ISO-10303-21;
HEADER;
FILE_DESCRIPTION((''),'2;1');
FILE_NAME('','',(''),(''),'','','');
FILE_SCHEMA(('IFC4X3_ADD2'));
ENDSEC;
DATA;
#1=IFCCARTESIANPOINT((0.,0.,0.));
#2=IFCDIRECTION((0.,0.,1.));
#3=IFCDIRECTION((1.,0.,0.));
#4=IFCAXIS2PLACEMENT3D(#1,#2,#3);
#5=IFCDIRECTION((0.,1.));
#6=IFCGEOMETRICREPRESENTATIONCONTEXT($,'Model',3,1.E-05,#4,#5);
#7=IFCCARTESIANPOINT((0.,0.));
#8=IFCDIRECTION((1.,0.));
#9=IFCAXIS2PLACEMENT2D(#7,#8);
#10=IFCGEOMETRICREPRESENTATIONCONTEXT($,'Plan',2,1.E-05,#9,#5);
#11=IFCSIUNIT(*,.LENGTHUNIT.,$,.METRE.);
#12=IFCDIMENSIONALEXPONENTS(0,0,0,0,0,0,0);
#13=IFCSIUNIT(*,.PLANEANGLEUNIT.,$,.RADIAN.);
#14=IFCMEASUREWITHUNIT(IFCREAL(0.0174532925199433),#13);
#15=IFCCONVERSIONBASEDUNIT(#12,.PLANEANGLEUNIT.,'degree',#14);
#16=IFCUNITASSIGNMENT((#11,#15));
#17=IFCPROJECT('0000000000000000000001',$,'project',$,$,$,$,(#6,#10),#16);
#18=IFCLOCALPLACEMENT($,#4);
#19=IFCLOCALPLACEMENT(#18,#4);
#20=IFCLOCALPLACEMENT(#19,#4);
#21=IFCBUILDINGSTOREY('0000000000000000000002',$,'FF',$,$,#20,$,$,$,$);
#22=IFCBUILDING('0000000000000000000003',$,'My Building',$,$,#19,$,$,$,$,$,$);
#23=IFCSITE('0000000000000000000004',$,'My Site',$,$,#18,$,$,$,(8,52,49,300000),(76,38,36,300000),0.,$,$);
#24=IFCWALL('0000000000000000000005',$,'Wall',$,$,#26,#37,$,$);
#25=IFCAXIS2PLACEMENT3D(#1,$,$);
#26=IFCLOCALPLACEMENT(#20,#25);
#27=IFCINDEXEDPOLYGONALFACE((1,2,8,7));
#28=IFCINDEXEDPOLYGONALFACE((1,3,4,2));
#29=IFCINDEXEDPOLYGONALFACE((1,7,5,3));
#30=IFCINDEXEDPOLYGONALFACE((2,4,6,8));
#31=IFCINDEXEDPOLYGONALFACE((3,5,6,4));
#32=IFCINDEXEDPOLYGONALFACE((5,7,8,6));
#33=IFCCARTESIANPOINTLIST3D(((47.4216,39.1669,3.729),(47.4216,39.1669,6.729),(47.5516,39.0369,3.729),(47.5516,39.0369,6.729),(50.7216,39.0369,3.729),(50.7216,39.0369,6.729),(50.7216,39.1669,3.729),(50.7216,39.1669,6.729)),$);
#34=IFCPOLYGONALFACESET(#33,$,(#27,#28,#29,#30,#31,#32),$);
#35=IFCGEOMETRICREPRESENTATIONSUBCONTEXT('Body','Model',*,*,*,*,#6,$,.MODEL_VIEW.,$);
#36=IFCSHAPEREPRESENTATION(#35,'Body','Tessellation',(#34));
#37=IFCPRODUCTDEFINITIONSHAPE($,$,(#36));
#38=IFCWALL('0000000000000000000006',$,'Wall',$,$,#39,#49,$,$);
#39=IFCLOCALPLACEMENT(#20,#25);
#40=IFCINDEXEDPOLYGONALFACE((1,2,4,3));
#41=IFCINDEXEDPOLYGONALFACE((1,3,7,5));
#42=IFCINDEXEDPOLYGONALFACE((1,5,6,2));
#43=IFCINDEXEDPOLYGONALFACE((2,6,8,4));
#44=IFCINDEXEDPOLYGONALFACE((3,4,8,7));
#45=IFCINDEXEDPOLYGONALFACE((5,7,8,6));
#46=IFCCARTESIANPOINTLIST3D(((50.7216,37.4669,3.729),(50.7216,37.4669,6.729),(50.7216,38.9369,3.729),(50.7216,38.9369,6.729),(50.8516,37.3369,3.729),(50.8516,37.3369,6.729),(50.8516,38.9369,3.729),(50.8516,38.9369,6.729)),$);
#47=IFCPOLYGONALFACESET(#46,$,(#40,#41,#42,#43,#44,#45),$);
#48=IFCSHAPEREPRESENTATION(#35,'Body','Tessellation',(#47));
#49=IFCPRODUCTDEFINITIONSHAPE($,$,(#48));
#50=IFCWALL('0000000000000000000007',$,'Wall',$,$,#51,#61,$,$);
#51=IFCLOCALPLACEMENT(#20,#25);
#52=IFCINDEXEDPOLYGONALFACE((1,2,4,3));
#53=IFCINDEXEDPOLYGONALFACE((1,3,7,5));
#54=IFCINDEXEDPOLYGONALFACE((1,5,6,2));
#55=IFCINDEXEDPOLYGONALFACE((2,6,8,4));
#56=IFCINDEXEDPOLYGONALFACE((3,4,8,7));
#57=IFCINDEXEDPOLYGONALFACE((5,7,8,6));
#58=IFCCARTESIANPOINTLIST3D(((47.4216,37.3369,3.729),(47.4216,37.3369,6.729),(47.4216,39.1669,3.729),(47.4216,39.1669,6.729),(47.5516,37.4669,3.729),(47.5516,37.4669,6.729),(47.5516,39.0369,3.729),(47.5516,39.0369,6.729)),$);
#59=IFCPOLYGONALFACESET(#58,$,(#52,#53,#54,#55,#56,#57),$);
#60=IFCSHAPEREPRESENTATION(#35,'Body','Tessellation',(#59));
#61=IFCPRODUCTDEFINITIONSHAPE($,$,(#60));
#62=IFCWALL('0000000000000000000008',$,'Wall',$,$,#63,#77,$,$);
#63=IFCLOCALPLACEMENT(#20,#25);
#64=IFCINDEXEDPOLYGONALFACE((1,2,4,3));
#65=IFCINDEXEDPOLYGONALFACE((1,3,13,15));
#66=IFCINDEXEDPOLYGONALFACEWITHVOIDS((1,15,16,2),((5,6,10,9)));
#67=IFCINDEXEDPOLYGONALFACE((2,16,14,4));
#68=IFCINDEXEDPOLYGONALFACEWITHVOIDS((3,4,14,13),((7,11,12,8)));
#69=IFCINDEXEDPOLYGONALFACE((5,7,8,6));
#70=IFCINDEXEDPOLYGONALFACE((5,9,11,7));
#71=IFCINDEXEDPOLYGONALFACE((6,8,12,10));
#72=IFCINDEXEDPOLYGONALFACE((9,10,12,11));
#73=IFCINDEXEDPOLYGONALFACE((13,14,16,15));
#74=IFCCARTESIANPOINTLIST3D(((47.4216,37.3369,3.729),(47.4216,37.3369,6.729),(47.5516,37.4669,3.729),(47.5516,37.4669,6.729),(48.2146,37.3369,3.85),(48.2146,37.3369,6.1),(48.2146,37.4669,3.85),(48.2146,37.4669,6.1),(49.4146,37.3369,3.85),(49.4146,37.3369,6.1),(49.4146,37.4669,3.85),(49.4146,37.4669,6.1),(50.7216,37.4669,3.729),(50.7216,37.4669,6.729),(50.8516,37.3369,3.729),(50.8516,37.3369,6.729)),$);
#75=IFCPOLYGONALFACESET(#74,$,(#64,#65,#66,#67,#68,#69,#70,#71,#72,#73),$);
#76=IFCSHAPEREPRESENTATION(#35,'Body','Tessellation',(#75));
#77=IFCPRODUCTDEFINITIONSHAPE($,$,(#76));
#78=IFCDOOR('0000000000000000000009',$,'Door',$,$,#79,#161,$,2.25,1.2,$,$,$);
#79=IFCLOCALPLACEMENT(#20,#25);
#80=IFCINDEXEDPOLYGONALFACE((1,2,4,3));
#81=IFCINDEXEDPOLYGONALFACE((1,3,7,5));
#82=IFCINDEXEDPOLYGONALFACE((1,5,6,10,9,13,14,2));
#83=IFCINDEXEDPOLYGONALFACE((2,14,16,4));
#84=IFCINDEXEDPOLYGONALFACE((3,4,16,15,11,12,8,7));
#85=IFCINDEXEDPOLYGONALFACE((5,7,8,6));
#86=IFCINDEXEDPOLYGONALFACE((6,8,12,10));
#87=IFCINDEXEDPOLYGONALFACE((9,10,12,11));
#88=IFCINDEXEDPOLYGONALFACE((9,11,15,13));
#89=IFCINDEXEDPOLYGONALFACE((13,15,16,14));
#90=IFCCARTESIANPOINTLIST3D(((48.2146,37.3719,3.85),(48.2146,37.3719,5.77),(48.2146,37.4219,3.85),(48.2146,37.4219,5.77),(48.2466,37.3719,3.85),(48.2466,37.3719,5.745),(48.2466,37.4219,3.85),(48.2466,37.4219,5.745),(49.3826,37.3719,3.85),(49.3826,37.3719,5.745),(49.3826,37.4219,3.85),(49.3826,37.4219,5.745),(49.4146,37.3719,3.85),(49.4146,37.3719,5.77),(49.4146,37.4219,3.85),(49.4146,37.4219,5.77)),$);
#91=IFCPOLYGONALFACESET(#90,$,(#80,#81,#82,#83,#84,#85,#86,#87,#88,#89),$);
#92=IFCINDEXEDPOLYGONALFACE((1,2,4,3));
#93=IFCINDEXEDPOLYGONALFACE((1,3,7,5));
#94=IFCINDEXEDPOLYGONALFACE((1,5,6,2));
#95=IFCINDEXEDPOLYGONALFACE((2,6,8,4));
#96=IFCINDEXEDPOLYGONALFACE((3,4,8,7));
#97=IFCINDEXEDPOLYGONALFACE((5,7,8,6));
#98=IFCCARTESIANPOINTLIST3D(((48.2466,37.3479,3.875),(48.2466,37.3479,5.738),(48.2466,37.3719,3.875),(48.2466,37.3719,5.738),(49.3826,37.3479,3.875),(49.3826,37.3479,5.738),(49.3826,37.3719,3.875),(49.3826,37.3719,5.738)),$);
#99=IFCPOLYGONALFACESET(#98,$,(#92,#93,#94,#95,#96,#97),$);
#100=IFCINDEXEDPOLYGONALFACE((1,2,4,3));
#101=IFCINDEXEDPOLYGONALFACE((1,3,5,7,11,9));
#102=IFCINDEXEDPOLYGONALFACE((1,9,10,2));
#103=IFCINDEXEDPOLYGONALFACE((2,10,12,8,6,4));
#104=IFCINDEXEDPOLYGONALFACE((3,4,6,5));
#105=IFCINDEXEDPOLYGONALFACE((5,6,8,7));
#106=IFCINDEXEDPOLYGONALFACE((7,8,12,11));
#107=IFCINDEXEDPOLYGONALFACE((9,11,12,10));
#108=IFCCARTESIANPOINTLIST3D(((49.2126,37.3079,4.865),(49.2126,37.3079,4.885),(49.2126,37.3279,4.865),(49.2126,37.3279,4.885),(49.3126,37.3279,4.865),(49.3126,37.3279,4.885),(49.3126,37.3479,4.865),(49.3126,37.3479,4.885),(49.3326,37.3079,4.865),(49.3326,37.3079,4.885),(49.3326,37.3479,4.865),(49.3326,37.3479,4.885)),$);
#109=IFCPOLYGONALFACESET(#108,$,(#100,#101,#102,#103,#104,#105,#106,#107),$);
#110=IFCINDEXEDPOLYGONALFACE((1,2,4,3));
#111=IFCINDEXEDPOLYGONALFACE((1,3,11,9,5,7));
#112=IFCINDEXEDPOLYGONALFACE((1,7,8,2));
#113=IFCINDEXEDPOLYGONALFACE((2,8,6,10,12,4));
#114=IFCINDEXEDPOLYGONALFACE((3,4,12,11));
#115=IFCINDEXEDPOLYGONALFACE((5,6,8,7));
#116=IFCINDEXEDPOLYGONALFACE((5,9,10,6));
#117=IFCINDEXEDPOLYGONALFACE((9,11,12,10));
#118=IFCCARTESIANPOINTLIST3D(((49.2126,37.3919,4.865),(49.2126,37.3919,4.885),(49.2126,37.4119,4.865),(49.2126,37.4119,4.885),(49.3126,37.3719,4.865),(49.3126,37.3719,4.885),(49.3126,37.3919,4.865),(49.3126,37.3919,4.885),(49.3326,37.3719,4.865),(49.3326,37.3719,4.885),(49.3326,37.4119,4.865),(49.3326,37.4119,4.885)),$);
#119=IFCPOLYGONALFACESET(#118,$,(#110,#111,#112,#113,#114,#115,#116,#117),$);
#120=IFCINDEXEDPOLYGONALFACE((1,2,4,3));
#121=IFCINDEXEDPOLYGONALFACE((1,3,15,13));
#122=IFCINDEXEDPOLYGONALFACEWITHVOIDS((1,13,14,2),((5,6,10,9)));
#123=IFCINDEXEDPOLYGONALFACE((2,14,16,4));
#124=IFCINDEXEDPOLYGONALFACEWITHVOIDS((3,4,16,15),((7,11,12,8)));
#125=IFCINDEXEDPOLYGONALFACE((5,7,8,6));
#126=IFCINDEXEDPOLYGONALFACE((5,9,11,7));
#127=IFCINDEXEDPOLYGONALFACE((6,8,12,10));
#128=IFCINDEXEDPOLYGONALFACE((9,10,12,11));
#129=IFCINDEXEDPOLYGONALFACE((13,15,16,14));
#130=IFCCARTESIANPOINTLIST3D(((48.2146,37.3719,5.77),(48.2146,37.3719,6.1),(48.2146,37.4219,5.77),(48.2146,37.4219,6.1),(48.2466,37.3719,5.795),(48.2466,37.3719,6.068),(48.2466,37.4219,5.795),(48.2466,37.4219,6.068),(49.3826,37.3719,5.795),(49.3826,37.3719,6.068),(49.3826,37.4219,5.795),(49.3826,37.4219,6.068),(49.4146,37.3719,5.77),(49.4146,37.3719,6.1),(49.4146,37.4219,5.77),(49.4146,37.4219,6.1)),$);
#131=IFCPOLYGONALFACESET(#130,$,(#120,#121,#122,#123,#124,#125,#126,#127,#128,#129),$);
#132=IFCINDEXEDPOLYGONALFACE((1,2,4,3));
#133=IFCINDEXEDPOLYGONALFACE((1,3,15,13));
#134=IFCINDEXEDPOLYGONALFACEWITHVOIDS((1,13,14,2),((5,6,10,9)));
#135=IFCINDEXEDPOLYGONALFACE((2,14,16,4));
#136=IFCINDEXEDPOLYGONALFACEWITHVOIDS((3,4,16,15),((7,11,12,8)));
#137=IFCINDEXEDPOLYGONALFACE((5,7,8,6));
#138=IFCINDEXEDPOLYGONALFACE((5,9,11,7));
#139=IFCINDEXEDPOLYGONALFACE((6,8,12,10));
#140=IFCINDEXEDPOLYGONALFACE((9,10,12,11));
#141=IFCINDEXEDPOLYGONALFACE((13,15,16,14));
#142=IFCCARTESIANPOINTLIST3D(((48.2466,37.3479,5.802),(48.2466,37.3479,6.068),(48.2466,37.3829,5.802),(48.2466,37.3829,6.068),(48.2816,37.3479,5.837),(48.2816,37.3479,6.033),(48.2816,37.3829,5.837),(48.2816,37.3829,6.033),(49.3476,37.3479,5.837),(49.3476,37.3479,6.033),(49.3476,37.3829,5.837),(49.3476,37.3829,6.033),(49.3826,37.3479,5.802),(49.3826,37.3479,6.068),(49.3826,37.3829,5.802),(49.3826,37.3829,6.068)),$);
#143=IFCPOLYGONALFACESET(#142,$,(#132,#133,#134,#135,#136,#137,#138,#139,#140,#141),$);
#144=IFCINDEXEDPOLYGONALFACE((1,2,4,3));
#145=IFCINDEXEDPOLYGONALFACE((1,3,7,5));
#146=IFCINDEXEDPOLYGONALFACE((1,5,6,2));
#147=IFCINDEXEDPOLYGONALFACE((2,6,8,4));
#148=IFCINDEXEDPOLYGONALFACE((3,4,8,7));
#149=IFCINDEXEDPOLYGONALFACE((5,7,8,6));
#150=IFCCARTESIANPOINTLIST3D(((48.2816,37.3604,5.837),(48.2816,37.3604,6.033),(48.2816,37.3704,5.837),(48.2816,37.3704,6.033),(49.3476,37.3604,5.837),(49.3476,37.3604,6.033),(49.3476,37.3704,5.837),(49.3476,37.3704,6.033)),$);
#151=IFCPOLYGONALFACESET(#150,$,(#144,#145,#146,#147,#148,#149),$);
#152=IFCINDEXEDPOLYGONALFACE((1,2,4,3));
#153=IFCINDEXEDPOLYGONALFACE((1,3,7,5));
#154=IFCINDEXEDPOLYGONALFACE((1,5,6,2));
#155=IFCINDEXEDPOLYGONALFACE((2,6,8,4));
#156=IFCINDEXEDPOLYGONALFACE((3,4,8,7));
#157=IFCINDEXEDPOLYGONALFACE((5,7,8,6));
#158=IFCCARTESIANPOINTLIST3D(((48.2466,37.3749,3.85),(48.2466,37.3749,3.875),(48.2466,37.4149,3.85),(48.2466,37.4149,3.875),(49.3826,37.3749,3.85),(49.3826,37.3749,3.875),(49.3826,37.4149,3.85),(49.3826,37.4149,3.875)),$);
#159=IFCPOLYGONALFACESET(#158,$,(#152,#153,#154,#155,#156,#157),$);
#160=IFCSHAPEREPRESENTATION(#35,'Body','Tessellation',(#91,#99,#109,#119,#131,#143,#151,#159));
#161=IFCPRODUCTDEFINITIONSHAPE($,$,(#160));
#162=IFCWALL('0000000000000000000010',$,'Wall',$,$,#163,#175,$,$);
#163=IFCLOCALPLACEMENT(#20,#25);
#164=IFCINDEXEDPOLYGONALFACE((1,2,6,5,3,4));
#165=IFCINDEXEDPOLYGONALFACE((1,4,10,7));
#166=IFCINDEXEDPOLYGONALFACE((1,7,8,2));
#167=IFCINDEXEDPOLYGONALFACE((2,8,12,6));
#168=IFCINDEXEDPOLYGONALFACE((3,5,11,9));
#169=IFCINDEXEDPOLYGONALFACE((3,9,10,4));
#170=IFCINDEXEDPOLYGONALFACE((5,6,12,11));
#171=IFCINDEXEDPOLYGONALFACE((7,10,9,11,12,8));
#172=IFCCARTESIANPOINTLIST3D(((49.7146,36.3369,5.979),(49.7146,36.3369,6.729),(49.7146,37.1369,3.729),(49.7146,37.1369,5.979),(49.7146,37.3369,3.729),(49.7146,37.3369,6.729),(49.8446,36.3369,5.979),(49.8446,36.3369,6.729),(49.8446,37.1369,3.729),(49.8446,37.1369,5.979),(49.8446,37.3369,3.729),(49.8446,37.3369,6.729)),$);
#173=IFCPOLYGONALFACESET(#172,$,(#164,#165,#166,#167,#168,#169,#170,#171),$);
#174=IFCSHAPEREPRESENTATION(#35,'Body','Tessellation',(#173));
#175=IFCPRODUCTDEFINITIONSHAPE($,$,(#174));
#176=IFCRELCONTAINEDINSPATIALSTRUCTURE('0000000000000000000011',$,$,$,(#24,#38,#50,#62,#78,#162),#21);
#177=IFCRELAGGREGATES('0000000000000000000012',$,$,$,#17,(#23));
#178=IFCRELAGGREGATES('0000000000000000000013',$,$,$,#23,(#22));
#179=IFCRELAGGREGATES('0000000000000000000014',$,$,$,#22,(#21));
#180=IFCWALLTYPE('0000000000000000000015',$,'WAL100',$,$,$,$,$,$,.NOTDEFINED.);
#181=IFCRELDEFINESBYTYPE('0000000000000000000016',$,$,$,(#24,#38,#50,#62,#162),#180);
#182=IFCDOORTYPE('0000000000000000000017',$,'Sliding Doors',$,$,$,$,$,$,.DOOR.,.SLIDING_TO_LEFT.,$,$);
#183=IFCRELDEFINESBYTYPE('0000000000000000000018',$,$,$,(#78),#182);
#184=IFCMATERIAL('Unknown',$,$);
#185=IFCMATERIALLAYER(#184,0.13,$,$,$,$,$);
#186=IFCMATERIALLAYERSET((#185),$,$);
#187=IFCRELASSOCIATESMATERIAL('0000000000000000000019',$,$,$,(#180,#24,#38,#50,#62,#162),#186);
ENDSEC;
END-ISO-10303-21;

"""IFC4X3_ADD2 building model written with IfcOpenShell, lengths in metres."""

from ifc_helpers import new_model, entity, si_unit, converted_unit, direction, frame, origin_with_axes, origin_2d_with_axis, place, context, subcontext, project, spatial, line, indexed_curve, outline, extrude, shape, source, transform, mapped, material, layer, layer_set, layer_usage, type_object, type_shapes, element, fill, save


model = new_model("IFC4X3_ADD2")

# Units and contexts
model_context = context("Model", 3, precision=1e-05, world=origin_with_axes(), true_north=direction((0.0, 1.0)))
plan_context = context("Plan", 2, precision=1e-05, world=origin_2d_with_axis(), true_north=direction((0.0, 1.0)))
body_context_1 = subcontext(model_context, "Body", "Model", "MODEL_VIEW")
body_context_2 = subcontext(plan_context, "Body", "Plan", "PLAN_VIEW")
ifc_project = project(units=[si_unit("LENGTHUNIT", "METRE"), converted_unit("PLANEANGLEUNIT", "degree", entity("IfcReal", 0.0174532925199433), si_unit("PLANEANGLEUNIT", "RADIAN"), dimensions=[0, 0, 0, 0, 0, 0, 0])], contexts=[model_context, plan_context])

# Site, building, storey
site_placement = place(None, origin_with_axes())
site = spatial("IfcSite", under=ifc_project, at=site_placement, Name="My Site", RefLatitude=(8, 52, 49, 300000), RefLongitude=(76, 38, 36, 300000), RefElevation=0.0)
building_placement = place(site_placement, origin_with_axes())
building = spatial("IfcBuilding", under=site, at=building_placement, Name="My Building")
storey_placement = place(building_placement, origin_with_axes())
storey = spatial("IfcBuildingStorey", under=building, at=storey_placement, Name="FF")

# Walls
ifc_material_1 = material(Name="Unknown")
ifc_layer_1 = layer(ifc_material_1, 0.13)
ifc_layer_set_1 = layer_set([ifc_layer_1])
ifc_layer_usage_1 = layer_usage(ifc_layer_set_1, "AXIS2", "POSITIVE", 0.0)
wall_type_1 = type_object("IfcWallType", Name="WAL100", PredefinedType="NOTDEFINED", material=ifc_layer_set_1)
wall_1_placement = place(storey_placement, frame((50.7216, 39.1669, 3.729), z_axis=(0.0, 0.0, 1.0), x_axis=(-1.0, 0.0, 0.0)))
element("IfcWall", 1, at=wall_1_placement, inside=storey, type_object=wall_type_1, material=ifc_layer_usage_1, Name="Wall", context=body_context_1, shape_type="SweptSolid", body=[
    extrude(outline(indexed_curve([(0.0, 0.0), (0.0, 0.13), (3.17, 0.13), (3.3, 0.0)], segments=[line(1, 2, 3, 4, 1)])), origin_with_axes(), (0.0, 0.0, 1.0), 3.0),
])
ifc_layer_usage_2 = layer_usage(ifc_layer_set_1, "AXIS2", "POSITIVE", 0.0)
wall_2_placement = place(storey_placement, frame((50.7216, 38.9369, 3.729), z_axis=(0.0, 0.0, 1.0), x_axis=(-0.000001, -1.0, 0.0)))
element("IfcWall", 2, at=wall_2_placement, inside=storey, type_object=wall_type_1, material=ifc_layer_usage_2, Name="Wall", context=body_context_1, shape_type="SweptSolid", body=[
    extrude(outline(indexed_curve([(0.0, 0.0), (0.0, 0.13), (1.6, 0.13), (1.47, 0.0)], segments=[line(1, 2, 3, 4, 1)])), origin_with_axes(), (0.0, 0.0, 1.0), 3.0),
])
ifc_layer_usage_3 = layer_usage(ifc_layer_set_1, "AXIS2", "POSITIVE", 0.0)
wall_3_placement = place(storey_placement, frame((47.4216, 39.1669, 3.729), z_axis=(0.0, 0.0, 1.0), x_axis=(-0.000001, -1.0, 0.0)))
element("IfcWall", 3, at=wall_3_placement, inside=storey, type_object=wall_type_1, material=ifc_layer_usage_3, Name="Wall", context=body_context_1, shape_type="SweptSolid", body=[
    extrude(outline(indexed_curve([(0.0, 0.0), (0.13, 0.13), (1.7, 0.13), (1.83, 0.0)], segments=[line(1, 2, 3, 4, 1)])), origin_with_axes(), (0.0, 0.0, 1.0), 3.0),
])

# Wall, opening, door
ifc_layer_usage_4 = layer_usage(ifc_layer_set_1, "AXIS2", "POSITIVE", 0.0)
wall_4_placement = place(storey_placement, frame((47.4216, 37.3369, 3.729), z_axis=(0.0, 0.0, 1.0), x_axis=(1.0, -0.000001, 0.0)))
wall_4 = element("IfcWall", 4, at=wall_4_placement, inside=storey, type_object=wall_type_1, material=ifc_layer_usage_4, Name="Wall", context=body_context_1, shape_type="SweptSolid", body=[
    extrude(outline(indexed_curve([(0.0, 0.0), (0.13, 0.13), (3.3, 0.13), (3.43, 0.0)], segments=[line(1, 2, 3, 4, 1)])), origin_with_axes(), (0.0, 0.0, 1.0), 3.0),
])
shared_shape_1 = source(origin_with_axes(), body_context_1, "Body", "SweptSolid", [
    extrude(outline(indexed_curve([(0.0, 0.0), (1.2, 0.0), (1.2, 2.25), (0.0, 2.25)], segments=[line(1, 2, 3, 4, 1)])), frame((0.0, -0.6, 0.0), z_axis=(0.0, -1.0, 0.0), x_axis=(1.0, 0.0, 0.0)), (0.0, 0.0, -1.0), 1.2),
])
opening_1_placement = place(wall_4_placement, frame((0.7929, 0.0, 0.121), z_axis=(0.0, 0.0, 1.0), x_axis=(1.0, 0.0, 0.0)))
opening_1 = element("IfcOpeningElement", 5, at=opening_1_placement, cuts=wall_4, PredefinedType="OPENING", context=body_context_1, shape_type="MappedRepresentation", body=[
    mapped(shared_shape_1, transform((0.0, 0.0, 0.0), x_axis=(1.0, 0.0, 0.0), y_axis=(0.0, 1.0, 0.0), z_axis=(0.0, 0.0, 1.0), scale=1.0)),
])
door_type = type_object("IfcDoorType", Name="Sliding Doors", OperationType="SLIDING_TO_LEFT", PredefinedType="DOOR")
shared_shape_2 = source(origin_with_axes(), body_context_1, "Body", "SweptSolid", [
    extrude(outline(indexed_curve([(0.0, 0.0), (0.0, 1.92), (1.2, 1.92), (1.2, 0.0), (1.168, 0.0), (1.168, 1.895), (0.032, 1.895), (0.032, 0.0)], segments=[line(1, 2, 3, 4, 5, 6, 7, 8, 1)])), frame((0.0, 0.035, 0.0), z_axis=(0.0, -1.0, 0.0), x_axis=(1.0, 0.0, 0.0)), (0.0, 0.0, -1.0), 0.05),
    extrude(outline(indexed_curve([(0.0, 0.0), (1.136, 0.0), (1.136, 0.024), (0.0, 0.024)], segments=[line(1, 2, 3, 4, 1)])), frame((0.032, 0.011, 0.025), z_axis=(0.0, 0.0, 1.0), x_axis=(1.0, 0.0, 0.0)), (0.0, 0.0, 1.0), 1.863),
    extrude(outline(indexed_curve([(0.0, 0.0), (0.0, -0.04), (-0.12, -0.04), (-0.12, -0.02), (-0.02, -0.02), (-0.02, 0.0)], segments=[line(1, 2, 3, 4, 5, 6, 1)])), frame((1.118, 0.011, 1.015), z_axis=(0.0, 0.0, 1.0), x_axis=(1.0, 0.0, 0.0)), (0.0, 0.0, 1.0), 0.02),
    extrude(outline(indexed_curve([(0.0, 0.0), (0.0, 0.04), (-0.12, 0.04), (-0.12, 0.02), (-0.02, 0.02), (-0.02, 0.0)], segments=[line(1, 2, 3, 4, 5, 6, 1)])), frame((1.118, 0.035, 1.015), z_axis=(0.0, 0.0, 1.0), x_axis=(1.0, 0.0, 0.0)), (0.0, 0.0, 1.0), 0.02),
    extrude(outline(indexed_curve([(0.0, 0.0), (1.2, 0.0), (1.2, 0.33), (0.0, 0.33)], segments=[line(1, 2, 3, 4, 1)]), holes=[indexed_curve([(0.032, 0.025), (1.168, 0.025), (1.168, 0.298), (0.032, 0.298)], segments=[line(1, 2, 3, 4, 1)])]), frame((0.0, 0.035, 1.92), z_axis=(0.0, -1.0, 0.0), x_axis=(1.0, 0.0, 0.0)), (0.0, 0.0, -1.0), 0.05),
    extrude(outline(indexed_curve([(0.0, 0.0), (1.136, 0.0), (1.136, 0.266), (0.0, 0.266)], segments=[line(1, 2, 3, 4, 1)]), holes=[indexed_curve([(0.035, 0.035), (1.101, 0.035), (1.101, 0.231), (0.035, 0.231)], segments=[line(1, 2, 3, 4, 1)])]), frame((0.032, 0.011, 1.952), z_axis=(0.0, -1.0, 0.0), x_axis=(1.0, 0.0, 0.0)), (0.0, 0.0, -1.0), 0.035),
    extrude(outline(indexed_curve([(0.035, 0.035), (1.101, 0.035), (1.101, 0.231), (0.035, 0.231)], segments=[line(1, 2, 3, 4, 1)])), frame((0.032, 0.0235, 1.952), z_axis=(0.0, -1.0, 0.0), x_axis=(1.0, 0.0, 0.0)), (0.0, 0.0, -1.0), 0.01),
    extrude(outline(indexed_curve([(0.0, 0.0), (1.136, 0.0), (1.136, 0.04), (0.0, 0.04)], segments=[line(1, 2, 3, 4, 1)])), frame((0.032, 0.038, 0.0), z_axis=(0.0, 0.0, 1.0), x_axis=(1.0, 0.0, 0.0)), (0.0, 0.0, 1.0), 0.025),
])
shared_shape_3 = source(origin_with_axes(), body_context_2, "Body", "Curve2D", [
    entity("IfcIndexedPolyCurve", entity("IfcCartesianPointList2D", [[0.0, 0.035], [0.032, 0.035], [0.032, 0.085], [0.0, 0.085]]), [entity("IfcLineIndex", [1, 2, 3, 4, 1])]),
    entity("IfcIndexedPolyCurve", entity("IfcCartesianPointList2D", [[1.2, 0.035], [1.168, 0.035], [1.168, 0.085], [1.2, 0.085]]), [entity("IfcLineIndex", [1, 2, 3, 4, 1])]),
    entity("IfcIndexedPolyCurve", entity("IfcCartesianPointList2D", [[-0.536, 0.011], [0.6, 0.011], [0.6, 0.035], [-0.536, 0.035]]), [entity("IfcLineIndex", [1, 2, 3, 4, 1])]),
])
type_shapes(door_type, [shared_shape_2, shared_shape_3])
door_placement = place(opening_1_placement, frame((0.0, 0.0, 0.0), z_axis=(0.0, 0.0, 1.0), x_axis=(1.0, 0.0, 0.0)))
door = element("IfcDoor", 6, at=door_placement, inside=storey, type_object=door_type, Name="Door", OverallHeight=2.25, OverallWidth=1.2, shapes=[
    shape(body_context_1, "Body", "MappedRepresentation", [mapped(shared_shape_2, transform((0.0, 0.0, 0.0), x_axis=(1.0, 0.0, 0.0), y_axis=(0.0, 1.0, 0.0), z_axis=(0.0, 0.0, 1.0), scale=1.0))]),
    shape(body_context_2, "Body", "MappedRepresentation", [mapped(shared_shape_3, transform((0.0, 0.0, 0.0), x_axis=(1.0, 0.0, 0.0), y_axis=(0.0, 1.0, 0.0), z_axis=(0.0, 0.0, 1.0), scale=1.0))]),
])
fill(opening_1, door)

# Wall, opening
ifc_layer_usage_5 = layer_usage(ifc_layer_set_1, "AXIS2", "POSITIVE", 0.0)
wall_5_placement = place(storey_placement, frame((49.7146, 37.3369, 3.729), z_axis=(0.0, 0.0, 1.0), x_axis=(-0.000001, -1.0, 0.0)))
wall_5 = element("IfcWall", 7, at=wall_5_placement, inside=storey, type_object=wall_type_1, material=ifc_layer_usage_5, Name="Wall", context=body_context_1, shape_type="SweptSolid", body=[
    extrude(outline(indexed_curve([(0.0, 0.0), (0.0, 0.13), (1.0, 0.13), (1.0, 0.0)], segments=[line(1, 2, 3, 4, 1)])), origin_with_axes(), (0.0, 0.0, 1.0), 3.0),
])
shared_shape_4 = source(origin_with_axes(), body_context_1, "Body", "SweptSolid", [
    extrude(outline(indexed_curve([(0.0, 0.0), (0.8, 0.0), (0.8, 2.25), (0.0, 2.25)], segments=[line(1, 2, 3, 4, 1)])), frame((0.0, -0.6, 0.0), z_axis=(0.0, -1.0, 0.0), x_axis=(1.0, 0.0, 0.0)), (0.0, 0.0, -1.0), 1.2),
])
opening_2_placement = place(wall_5_placement, frame((0.2, 0.0, 0.0), z_axis=(0.0, 0.0, 1.0), x_axis=(1.0, 0.0, 0.0)))
element("IfcOpeningElement", 8, at=opening_2_placement, cuts=wall_5, PredefinedType="OPENING", context=body_context_1, shape_type="MappedRepresentation", body=[
    mapped(shared_shape_4, transform((0.0, 0.0, 0.0), x_axis=(1.0, 0.0, 0.0), y_axis=(0.0, 1.0, 0.0), z_axis=(0.0, 0.0, 1.0), scale=1.0)),
])

save(model, "model.ifc")
